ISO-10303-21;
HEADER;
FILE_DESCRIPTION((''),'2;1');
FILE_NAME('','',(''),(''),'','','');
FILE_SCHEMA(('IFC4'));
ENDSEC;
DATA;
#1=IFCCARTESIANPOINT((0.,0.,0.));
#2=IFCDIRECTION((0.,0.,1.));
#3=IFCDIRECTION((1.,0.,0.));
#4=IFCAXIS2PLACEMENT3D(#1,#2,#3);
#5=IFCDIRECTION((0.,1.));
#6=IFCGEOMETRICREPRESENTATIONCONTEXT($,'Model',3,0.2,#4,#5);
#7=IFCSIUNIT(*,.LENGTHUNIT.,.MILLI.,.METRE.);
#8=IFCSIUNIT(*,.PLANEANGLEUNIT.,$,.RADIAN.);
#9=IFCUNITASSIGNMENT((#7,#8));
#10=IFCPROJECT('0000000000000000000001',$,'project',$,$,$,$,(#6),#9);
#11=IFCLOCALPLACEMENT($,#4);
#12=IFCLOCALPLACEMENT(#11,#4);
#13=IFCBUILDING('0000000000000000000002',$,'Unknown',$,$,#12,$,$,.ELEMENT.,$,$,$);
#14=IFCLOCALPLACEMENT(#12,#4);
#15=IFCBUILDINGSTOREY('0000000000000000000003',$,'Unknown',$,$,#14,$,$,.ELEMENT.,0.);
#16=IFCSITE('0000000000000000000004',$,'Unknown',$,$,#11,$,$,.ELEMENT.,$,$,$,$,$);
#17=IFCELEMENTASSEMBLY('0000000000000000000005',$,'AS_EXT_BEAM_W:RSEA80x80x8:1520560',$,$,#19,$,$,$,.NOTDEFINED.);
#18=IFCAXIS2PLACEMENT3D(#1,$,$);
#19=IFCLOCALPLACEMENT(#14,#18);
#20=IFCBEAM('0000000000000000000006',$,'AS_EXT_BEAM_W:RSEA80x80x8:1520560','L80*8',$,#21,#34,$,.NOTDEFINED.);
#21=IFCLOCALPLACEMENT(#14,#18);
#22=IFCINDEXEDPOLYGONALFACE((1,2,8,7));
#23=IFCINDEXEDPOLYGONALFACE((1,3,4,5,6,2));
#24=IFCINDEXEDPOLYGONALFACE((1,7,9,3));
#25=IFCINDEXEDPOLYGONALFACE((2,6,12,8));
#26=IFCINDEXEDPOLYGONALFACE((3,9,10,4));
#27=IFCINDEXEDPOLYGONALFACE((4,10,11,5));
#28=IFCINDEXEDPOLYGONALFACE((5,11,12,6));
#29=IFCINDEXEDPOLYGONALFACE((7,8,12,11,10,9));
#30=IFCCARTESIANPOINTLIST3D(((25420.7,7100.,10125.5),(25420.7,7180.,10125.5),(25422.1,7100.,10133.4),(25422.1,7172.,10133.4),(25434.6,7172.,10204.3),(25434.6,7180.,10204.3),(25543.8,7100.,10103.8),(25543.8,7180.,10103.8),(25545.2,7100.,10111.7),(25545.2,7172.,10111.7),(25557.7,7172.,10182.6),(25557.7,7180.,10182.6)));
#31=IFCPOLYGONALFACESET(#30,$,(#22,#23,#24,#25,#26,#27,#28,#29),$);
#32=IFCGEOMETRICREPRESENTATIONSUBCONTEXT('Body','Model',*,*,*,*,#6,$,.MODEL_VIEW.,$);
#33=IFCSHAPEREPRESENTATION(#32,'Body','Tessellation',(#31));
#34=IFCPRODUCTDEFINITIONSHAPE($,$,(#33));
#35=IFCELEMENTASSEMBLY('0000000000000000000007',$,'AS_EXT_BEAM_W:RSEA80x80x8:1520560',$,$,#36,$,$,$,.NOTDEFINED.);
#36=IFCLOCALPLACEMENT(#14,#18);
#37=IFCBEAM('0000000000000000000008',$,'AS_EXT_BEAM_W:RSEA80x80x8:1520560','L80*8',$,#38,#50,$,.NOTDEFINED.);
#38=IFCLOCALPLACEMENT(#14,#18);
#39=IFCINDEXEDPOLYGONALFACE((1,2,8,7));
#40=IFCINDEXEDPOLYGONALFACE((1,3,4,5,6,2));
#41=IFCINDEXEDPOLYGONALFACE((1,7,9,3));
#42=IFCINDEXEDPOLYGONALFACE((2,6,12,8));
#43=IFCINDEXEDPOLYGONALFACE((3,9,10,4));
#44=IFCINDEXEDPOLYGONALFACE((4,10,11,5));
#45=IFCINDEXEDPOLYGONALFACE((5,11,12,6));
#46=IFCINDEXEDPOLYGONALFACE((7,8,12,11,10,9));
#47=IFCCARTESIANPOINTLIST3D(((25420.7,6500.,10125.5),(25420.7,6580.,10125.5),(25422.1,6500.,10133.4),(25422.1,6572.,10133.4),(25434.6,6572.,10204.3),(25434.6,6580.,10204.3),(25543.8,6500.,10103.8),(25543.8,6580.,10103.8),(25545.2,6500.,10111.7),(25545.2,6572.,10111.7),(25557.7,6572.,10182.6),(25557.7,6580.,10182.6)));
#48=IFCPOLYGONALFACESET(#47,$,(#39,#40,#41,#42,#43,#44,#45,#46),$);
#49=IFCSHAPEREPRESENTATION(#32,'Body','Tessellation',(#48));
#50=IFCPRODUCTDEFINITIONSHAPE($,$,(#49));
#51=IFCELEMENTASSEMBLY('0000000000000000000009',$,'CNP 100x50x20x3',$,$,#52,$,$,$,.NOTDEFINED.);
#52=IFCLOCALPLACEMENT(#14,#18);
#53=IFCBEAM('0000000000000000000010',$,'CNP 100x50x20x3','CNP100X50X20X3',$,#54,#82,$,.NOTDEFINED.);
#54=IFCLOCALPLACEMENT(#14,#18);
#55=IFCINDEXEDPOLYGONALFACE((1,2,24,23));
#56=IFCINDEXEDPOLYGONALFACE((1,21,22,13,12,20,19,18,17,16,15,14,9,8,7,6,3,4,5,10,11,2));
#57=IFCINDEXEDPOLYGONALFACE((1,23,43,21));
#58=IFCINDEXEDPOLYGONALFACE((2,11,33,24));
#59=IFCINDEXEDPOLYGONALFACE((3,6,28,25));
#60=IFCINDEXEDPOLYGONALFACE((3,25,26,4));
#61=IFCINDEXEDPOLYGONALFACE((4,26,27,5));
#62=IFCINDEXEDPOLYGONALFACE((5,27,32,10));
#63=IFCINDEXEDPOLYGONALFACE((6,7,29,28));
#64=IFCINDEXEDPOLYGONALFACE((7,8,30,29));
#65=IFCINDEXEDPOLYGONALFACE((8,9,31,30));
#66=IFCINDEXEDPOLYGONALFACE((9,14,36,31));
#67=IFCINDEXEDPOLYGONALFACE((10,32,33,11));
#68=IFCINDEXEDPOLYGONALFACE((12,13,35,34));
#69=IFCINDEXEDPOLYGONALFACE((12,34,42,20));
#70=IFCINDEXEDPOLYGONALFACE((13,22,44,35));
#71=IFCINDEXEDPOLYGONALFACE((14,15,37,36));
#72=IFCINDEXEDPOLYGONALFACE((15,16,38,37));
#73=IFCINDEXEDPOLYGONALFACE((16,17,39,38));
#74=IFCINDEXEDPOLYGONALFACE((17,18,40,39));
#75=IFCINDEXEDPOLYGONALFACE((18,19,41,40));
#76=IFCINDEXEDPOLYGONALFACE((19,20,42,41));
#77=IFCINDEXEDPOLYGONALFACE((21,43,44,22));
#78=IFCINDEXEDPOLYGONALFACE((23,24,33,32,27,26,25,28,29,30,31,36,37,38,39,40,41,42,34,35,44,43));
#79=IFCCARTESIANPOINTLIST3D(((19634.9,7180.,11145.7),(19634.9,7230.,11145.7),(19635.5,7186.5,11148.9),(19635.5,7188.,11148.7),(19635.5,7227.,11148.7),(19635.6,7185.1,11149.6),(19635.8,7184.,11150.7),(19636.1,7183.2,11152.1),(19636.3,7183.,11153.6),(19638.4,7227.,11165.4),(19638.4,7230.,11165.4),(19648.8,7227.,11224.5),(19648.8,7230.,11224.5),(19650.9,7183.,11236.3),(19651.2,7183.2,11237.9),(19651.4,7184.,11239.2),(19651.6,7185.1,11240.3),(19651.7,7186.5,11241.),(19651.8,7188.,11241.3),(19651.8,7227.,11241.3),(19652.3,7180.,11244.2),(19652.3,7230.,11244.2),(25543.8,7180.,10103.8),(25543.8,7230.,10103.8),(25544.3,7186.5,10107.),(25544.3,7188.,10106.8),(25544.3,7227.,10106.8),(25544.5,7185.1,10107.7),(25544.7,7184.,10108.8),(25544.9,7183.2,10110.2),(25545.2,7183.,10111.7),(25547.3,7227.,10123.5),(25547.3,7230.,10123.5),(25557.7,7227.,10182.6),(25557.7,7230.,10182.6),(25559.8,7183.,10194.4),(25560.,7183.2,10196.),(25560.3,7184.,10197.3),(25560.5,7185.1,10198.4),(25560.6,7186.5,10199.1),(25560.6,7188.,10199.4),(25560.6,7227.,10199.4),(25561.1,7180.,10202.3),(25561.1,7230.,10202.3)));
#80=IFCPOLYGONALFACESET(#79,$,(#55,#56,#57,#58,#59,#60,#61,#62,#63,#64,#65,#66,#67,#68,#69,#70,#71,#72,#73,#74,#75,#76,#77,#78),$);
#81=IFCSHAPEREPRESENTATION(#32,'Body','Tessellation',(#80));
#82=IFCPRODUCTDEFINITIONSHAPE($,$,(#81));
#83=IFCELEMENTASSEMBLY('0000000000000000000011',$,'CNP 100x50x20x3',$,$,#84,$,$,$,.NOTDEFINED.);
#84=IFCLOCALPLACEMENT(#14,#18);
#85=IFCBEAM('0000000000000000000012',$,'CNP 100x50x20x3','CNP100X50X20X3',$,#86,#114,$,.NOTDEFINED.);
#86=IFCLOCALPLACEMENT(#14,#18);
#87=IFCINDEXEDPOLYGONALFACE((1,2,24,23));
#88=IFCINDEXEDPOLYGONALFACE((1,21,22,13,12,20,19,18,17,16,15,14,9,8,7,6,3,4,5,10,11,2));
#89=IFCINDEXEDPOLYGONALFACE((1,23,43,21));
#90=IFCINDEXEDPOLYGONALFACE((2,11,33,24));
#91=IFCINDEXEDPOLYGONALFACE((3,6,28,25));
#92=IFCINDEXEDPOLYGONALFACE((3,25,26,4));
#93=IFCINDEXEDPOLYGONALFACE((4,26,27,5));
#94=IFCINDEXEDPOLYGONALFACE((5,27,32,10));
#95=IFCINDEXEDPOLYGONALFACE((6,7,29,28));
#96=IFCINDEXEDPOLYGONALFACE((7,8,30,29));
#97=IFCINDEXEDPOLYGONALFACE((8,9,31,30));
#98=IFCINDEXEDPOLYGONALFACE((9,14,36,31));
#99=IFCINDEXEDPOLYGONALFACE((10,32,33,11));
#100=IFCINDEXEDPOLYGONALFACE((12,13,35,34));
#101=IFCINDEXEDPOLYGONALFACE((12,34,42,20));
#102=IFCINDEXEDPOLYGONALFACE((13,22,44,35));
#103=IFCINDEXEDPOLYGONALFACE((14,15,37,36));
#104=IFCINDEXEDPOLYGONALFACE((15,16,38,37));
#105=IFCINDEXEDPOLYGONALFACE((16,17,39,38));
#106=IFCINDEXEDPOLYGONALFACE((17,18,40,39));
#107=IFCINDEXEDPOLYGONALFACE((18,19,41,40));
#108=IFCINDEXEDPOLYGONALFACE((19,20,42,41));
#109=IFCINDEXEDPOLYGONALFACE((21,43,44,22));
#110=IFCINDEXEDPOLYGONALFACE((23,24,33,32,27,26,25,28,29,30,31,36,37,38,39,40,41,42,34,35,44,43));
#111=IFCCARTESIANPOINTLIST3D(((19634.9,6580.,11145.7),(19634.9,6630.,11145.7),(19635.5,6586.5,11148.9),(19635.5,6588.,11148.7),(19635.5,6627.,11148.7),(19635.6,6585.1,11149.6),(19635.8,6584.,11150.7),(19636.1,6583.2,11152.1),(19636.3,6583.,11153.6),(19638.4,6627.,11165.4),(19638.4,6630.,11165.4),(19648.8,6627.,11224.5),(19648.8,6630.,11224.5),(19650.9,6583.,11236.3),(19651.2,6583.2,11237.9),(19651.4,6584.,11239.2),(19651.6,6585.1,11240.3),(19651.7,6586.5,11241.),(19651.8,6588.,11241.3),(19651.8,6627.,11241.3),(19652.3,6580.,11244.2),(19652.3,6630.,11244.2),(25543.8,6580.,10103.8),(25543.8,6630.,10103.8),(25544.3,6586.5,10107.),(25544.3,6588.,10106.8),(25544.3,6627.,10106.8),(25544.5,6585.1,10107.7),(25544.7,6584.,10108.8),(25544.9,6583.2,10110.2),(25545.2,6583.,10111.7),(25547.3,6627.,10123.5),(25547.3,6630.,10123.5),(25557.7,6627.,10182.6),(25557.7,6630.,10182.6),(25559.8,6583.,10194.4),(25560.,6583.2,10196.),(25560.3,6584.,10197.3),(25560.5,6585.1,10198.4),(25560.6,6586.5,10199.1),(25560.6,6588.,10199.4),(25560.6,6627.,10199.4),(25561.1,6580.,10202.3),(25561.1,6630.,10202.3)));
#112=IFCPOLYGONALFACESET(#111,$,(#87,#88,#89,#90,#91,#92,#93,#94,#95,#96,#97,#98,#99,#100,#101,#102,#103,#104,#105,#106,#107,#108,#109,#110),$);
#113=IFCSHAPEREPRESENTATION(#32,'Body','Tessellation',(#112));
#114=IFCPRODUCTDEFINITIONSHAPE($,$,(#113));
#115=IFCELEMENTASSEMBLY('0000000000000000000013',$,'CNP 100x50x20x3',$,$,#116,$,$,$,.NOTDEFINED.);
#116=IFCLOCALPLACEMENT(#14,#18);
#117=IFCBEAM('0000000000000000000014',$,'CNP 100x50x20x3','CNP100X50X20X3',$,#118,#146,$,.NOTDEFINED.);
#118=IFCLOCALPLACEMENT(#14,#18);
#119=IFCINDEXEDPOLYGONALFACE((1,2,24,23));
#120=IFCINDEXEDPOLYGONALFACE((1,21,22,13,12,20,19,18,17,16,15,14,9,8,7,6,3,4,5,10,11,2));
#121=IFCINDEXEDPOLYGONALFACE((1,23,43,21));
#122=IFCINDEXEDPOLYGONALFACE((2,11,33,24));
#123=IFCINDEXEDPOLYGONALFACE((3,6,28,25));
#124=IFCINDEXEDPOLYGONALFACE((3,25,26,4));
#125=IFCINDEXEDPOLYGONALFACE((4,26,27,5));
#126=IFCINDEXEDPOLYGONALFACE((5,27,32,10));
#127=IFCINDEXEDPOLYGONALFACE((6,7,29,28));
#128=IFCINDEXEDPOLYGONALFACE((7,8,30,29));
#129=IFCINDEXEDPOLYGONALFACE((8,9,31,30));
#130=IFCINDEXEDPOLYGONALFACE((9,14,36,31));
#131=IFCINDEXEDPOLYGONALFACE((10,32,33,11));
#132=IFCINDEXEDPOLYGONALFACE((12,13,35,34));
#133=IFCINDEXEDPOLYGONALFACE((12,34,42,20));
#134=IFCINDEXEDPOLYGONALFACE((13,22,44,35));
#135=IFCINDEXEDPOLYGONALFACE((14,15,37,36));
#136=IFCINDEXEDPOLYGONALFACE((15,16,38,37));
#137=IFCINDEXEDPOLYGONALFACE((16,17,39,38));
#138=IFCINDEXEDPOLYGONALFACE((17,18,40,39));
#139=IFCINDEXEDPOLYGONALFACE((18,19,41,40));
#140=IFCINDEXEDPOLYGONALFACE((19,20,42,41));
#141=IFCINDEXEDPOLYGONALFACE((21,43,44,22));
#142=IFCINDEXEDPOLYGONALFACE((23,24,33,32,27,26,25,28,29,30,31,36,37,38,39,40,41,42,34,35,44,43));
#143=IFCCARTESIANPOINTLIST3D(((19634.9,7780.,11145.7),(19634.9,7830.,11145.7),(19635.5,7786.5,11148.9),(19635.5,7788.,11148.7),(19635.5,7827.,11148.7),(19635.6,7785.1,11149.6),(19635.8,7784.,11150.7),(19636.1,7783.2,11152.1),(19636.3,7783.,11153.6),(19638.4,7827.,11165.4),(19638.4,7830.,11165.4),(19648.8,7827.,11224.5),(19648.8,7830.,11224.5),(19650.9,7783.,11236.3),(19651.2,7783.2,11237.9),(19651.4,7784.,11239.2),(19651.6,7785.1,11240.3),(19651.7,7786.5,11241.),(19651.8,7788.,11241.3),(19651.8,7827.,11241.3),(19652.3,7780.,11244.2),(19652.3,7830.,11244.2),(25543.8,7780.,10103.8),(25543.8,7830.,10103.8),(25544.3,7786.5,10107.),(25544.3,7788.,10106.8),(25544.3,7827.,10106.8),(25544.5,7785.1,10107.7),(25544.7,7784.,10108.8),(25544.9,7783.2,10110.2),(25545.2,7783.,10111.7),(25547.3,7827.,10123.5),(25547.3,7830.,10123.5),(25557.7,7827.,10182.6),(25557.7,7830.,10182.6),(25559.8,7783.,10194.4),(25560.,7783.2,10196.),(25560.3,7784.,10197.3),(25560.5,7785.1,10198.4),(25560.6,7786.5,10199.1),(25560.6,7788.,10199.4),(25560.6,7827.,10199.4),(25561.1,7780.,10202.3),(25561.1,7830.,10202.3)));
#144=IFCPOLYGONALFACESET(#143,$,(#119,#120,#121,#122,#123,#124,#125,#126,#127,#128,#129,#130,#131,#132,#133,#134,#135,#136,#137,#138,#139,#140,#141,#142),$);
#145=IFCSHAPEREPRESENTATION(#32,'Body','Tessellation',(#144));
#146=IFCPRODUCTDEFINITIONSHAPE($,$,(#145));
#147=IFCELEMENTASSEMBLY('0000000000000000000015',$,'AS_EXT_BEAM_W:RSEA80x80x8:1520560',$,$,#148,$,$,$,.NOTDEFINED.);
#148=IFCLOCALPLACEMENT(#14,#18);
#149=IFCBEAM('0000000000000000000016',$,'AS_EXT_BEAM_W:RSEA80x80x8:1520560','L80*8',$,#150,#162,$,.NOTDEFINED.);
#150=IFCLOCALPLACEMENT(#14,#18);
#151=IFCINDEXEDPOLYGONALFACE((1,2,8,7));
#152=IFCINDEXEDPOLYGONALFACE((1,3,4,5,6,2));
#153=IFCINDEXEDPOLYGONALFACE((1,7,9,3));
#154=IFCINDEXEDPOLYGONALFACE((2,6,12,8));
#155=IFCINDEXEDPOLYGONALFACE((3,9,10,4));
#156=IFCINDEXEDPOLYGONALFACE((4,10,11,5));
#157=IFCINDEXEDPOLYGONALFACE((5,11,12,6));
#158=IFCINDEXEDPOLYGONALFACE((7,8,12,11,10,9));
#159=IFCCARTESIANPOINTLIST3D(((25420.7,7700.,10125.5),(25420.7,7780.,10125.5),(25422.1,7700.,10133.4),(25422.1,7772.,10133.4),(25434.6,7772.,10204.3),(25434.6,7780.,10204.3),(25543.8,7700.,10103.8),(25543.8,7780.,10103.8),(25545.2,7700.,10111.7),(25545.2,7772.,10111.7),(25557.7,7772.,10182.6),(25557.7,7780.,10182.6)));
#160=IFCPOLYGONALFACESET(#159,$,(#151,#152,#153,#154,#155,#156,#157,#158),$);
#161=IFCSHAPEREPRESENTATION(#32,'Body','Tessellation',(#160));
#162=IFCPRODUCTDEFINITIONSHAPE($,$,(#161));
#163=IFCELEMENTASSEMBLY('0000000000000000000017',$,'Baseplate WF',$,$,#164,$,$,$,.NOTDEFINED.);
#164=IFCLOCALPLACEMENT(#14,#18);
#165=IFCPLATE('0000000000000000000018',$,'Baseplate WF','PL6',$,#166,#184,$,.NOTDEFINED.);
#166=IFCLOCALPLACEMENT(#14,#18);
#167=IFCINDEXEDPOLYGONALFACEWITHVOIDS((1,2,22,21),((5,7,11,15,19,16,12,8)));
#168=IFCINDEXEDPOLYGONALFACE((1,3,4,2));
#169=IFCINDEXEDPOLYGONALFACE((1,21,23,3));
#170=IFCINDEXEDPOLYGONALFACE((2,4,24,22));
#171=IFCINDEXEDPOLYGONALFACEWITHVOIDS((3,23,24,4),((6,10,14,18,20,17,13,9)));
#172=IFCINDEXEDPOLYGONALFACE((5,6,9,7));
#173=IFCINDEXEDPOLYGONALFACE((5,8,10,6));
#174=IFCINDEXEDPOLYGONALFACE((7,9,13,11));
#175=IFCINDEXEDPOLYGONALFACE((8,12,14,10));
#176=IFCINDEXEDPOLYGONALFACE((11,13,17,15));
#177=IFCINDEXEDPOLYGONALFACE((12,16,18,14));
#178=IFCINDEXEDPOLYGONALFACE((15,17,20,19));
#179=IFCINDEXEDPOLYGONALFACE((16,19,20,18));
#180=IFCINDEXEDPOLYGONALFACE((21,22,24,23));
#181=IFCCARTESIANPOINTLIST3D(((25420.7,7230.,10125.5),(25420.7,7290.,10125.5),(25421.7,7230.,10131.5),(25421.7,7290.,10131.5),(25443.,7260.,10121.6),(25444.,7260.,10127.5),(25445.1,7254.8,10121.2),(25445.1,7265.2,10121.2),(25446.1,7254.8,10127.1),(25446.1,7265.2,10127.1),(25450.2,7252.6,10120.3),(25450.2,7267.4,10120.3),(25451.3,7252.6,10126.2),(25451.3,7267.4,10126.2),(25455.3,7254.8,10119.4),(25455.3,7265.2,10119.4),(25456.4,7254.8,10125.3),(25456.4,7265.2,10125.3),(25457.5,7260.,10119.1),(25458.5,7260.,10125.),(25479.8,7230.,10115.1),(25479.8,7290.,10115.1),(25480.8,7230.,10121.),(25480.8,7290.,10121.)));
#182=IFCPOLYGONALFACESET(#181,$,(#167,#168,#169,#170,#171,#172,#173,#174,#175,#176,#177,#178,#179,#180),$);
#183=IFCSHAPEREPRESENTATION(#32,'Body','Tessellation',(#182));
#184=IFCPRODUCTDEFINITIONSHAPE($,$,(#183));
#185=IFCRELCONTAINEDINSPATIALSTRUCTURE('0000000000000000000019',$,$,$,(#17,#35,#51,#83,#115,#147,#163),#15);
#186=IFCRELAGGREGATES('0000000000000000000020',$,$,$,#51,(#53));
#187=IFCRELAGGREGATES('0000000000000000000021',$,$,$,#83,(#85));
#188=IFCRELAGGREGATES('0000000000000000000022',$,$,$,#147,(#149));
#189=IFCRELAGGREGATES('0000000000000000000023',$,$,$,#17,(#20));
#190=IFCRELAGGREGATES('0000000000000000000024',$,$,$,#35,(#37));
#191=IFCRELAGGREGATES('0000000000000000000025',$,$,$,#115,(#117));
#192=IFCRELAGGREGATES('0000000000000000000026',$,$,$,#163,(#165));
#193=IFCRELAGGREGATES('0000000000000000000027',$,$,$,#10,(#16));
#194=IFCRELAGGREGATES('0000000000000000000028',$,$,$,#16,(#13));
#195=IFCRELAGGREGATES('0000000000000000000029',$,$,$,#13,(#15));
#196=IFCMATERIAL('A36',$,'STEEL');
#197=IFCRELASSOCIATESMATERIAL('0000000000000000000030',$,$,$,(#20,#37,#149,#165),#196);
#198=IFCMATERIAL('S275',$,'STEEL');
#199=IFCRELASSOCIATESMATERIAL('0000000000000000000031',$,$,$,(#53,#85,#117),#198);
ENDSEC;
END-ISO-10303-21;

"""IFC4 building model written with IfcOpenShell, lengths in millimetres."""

from ifc_helpers import new_model, si_unit, direction, frame, origin_with_axes, place, context, subcontext, project, spatial, line, indexed_curve, outline, extrude, material, element, aggregate, save


model = new_model("IFC4")

# Units and contexts
model_context = context("Model", 3, precision=0.2, world=origin_with_axes(), true_north=direction((0.0, 1.0)))
body_context = subcontext(model_context, "Body", "Model", "MODEL_VIEW")
ifc_project = project(units=[si_unit("LENGTHUNIT", "METRE", prefix="MILLI"), si_unit("PLANEANGLEUNIT", "RADIAN")], contexts=[model_context])

# Site, building, storey
site_placement = place(None, origin_with_axes())
site = spatial("IfcSite", under=ifc_project, at=site_placement, Name="Unknown", CompositionType="ELEMENT")
building_placement = place(site_placement, origin_with_axes())
building = spatial("IfcBuilding", under=site, at=building_placement, Name="Unknown", CompositionType="ELEMENT")
storey_placement = place(building_placement, origin_with_axes())
storey = spatial("IfcBuildingStorey", under=building, at=storey_placement, Name="Unknown", CompositionType="ELEMENT", Elevation=0.0)

# Element assemblies, beams
assembly_1_placement = place(storey_placement, frame((25427.6, 7140.0, 10164.9), z_axis=(0.0, -1.0, 0.0), x_axis=(0.984808, 0.0, -0.173648)))
assembly_1 = element("IfcElementAssembly", 1, at=assembly_1_placement, inside=storey, Name="AS_EXT_BEAM_W:RSEA80x80x8:1520560", PredefinedType="NOTDEFINED")
ifc_material_1 = material(Name="A36", Category="STEEL")
beam_1_placement = place(assembly_1_placement, origin_with_axes())
beam_1 = element("IfcBeam", 2, at=beam_1_placement, material=ifc_material_1, Name="AS_EXT_BEAM_W:RSEA80x80x8:1520560", Description="L80*8", PredefinedType="NOTDEFINED", context=body_context, shape_type="SolidModel", body=[
    extrude(outline(indexed_curve([(-40.0, -40.0), (40.0, -40.0), (40.0, -32.0), (-32.0, -32.0), (-32.0, 40.0), (-40.0, 40.0)], segments=[line(1, 2, 3, 4, 5, 6, 1)])), frame((0.0, 0.0, 0.0), z_axis=(-1.0, 0.0, 0.0), x_axis=(0.0, 0.0, 1.0)), (0.0, 0.0, -1.0), 125.0),
])
assembly_2_placement = place(storey_placement, frame((25427.6, 6540.0, 10164.9), z_axis=(0.0, -1.0, 0.0), x_axis=(0.984808, 0.0, -0.173648)))
assembly_2 = element("IfcElementAssembly", 3, at=assembly_2_placement, inside=storey, Name="AS_EXT_BEAM_W:RSEA80x80x8:1520560", PredefinedType="NOTDEFINED")
beam_2_placement = place(assembly_2_placement, origin_with_axes())
beam_2 = element("IfcBeam", 4, at=beam_2_placement, material=ifc_material_1, Name="AS_EXT_BEAM_W:RSEA80x80x8:1520560", Description="L80*8", PredefinedType="NOTDEFINED", context=body_context, shape_type="SolidModel", body=[
    extrude(outline(indexed_curve([(-40.0, -40.0), (40.0, -40.0), (40.0, -32.0), (-32.0, -32.0), (-32.0, 40.0), (-40.0, 40.0)], segments=[line(1, 2, 3, 4, 5, 6, 1)])), frame((0.0, 0.0, 0.0), z_axis=(-1.0, 0.0, 0.0), x_axis=(0.0, 0.0, 1.0)), (0.0, 0.0, -1.0), 125.0),
])
assembly_3_placement = place(storey_placement, frame((25552.5, 7205.0, 10153.1), z_axis=(0.173648, 0.0, 0.984808), x_axis=(-0.984808, 0.0, 0.173648)))
assembly_3 = element("IfcElementAssembly", 5, at=assembly_3_placement, inside=storey, Name="CNP 100x50x20x3", PredefinedType="NOTDEFINED")
ifc_material_2 = material(Name="S275", Category="STEEL")
beam_3_placement = place(assembly_3_placement, origin_with_axes())
beam_3 = element("IfcBeam", 6, at=beam_3_placement, material=ifc_material_2, Name="CNP 100x50x20x3", Description="CNP100X50X20X3", PredefinedType="NOTDEFINED", context=body_context, shape_type="SolidModel", body=[
    extrude(outline(indexed_curve([(50.0, -25.0), (50.0, 25.0), (-50.0, 25.0), (-50.0, -25.0), (-30.0, -25.0), (-30.0, -22.0), (-47.0, -22.0), (-47.0, 17.0), (-46.8, 18.5), (-46.0, 19.9), (-44.9, 21.0), (-43.5, 21.8), (-42.0, 22.0), (42.0, 22.0), (43.5, 21.8), (44.9, 21.0), (46.0, 19.9), (46.8, 18.5), (47.0, 17.0), (47.0, -22.0), (30.0, -22.0), (30.0, -25.0)], segments=[line(1, 2, 3, 4, 5, 6, 7, 8, 9, 10, 11, 12, 13, 14, 15, 16, 17, 18, 19, 20, 21, 22, 1)])), frame((0.0, 0.0, 0.0), z_axis=(-1.0, 0.0, 0.0), x_axis=(0.0, 0.0, 1.0)), (0.0, 0.0, -1.0), 6000.0),
])
aggregate(assembly_3, [beam_3])
assembly_4_placement = place(storey_placement, frame((25552.5, 6605.0, 10153.1), z_axis=(0.173648, 0.0, 0.984808), x_axis=(-0.984808, 0.0, 0.173648)))
assembly_4 = element("IfcElementAssembly", 7, at=assembly_4_placement, inside=storey, Name="CNP 100x50x20x3", PredefinedType="NOTDEFINED")
beam_4_placement = place(assembly_4_placement, origin_with_axes())
beam_4 = element("IfcBeam", 8, at=beam_4_placement, material=ifc_material_2, Name="CNP 100x50x20x3", Description="CNP100X50X20X3", PredefinedType="NOTDEFINED", context=body_context, shape_type="SolidModel", body=[
    extrude(outline(indexed_curve([(50.0, -25.0), (50.0, 25.0), (-50.0, 25.0), (-50.0, -25.0), (-30.0, -25.0), (-30.0, -22.0), (-47.0, -22.0), (-47.0, 17.0), (-46.8, 18.5), (-46.0, 19.9), (-44.9, 21.0), (-43.5, 21.8), (-42.0, 22.0), (42.0, 22.0), (43.5, 21.8), (44.9, 21.0), (46.0, 19.9), (46.8, 18.5), (47.0, 17.0), (47.0, -22.0), (30.0, -22.0), (30.0, -25.0)], segments=[line(1, 2, 3, 4, 5, 6, 7, 8, 9, 10, 11, 12, 13, 14, 15, 16, 17, 18, 19, 20, 21, 22, 1)])), frame((0.0, 0.0, 0.0), z_axis=(-1.0, 0.0, 0.0), x_axis=(0.0, 0.0, 1.0)), (0.0, 0.0, -1.0), 6000.0),
])
aggregate(assembly_4, [beam_4])
assembly_5_placement = place(storey_placement, frame((25552.5, 7805.0, 10153.1), z_axis=(0.173648, 0.0, 0.984808), x_axis=(-0.984808, 0.0, 0.173648)))
assembly_5 = element("IfcElementAssembly", 9, at=assembly_5_placement, inside=storey, Name="CNP 100x50x20x3", PredefinedType="NOTDEFINED")
beam_5_placement = place(assembly_5_placement, origin_with_axes())
beam_5 = element("IfcBeam", 10, at=beam_5_placement, material=ifc_material_2, Name="CNP 100x50x20x3", Description="CNP100X50X20X3", PredefinedType="NOTDEFINED", context=body_context, shape_type="SolidModel", body=[
    extrude(outline(indexed_curve([(50.0, -25.0), (50.0, 25.0), (-50.0, 25.0), (-50.0, -25.0), (-30.0, -25.0), (-30.0, -22.0), (-47.0, -22.0), (-47.0, 17.0), (-46.8, 18.5), (-46.0, 19.9), (-44.9, 21.0), (-43.5, 21.8), (-42.0, 22.0), (42.0, 22.0), (43.5, 21.8), (44.9, 21.0), (46.0, 19.9), (46.8, 18.5), (47.0, 17.0), (47.0, -22.0), (30.0, -22.0), (30.0, -25.0)], segments=[line(1, 2, 3, 4, 5, 6, 7, 8, 9, 10, 11, 12, 13, 14, 15, 16, 17, 18, 19, 20, 21, 22, 1)])), frame((0.0, 0.0, 0.0), z_axis=(-1.0, 0.0, 0.0), x_axis=(0.0, 0.0, 1.0)), (0.0, 0.0, -1.0), 6000.0),
])
assembly_6_placement = place(storey_placement, frame((25427.6, 7740.0, 10164.9), z_axis=(0.0, -1.0, 0.0), x_axis=(0.984808, 0.0, -0.173648)))
assembly_6 = element("IfcElementAssembly", 11, at=assembly_6_placement, inside=storey, Name="AS_EXT_BEAM_W:RSEA80x80x8:1520560", PredefinedType="NOTDEFINED")
beam_6_placement = place(assembly_6_placement, origin_with_axes())
beam_6 = element("IfcBeam", 12, at=beam_6_placement, material=ifc_material_1, Name="AS_EXT_BEAM_W:RSEA80x80x8:1520560", Description="L80*8", PredefinedType="NOTDEFINED", context=body_context, shape_type="SolidModel", body=[
    extrude(outline(indexed_curve([(-40.0, -40.0), (40.0, -40.0), (40.0, -32.0), (-32.0, -32.0), (-32.0, 40.0), (-40.0, 40.0)], segments=[line(1, 2, 3, 4, 5, 6, 1)])), frame((0.0, 0.0, 0.0), z_axis=(-1.0, 0.0, 0.0), x_axis=(0.0, 0.0, 1.0)), (0.0, 0.0, -1.0), 125.0),
])
aggregate(assembly_6, [beam_6])

# Element assembly, plate, voiding features
assembly_7_placement = place(storey_placement, frame((25480.3, 7290.0, 10118.1), z_axis=(-0.173648, 0.0, -0.984808), x_axis=(0.0, -1.0, 0.0)))
assembly_7 = element("IfcElementAssembly", 13, at=assembly_7_placement, inside=storey, Name="Baseplate WF", PredefinedType="NOTDEFINED")
plate_1_placement = place(assembly_7_placement, origin_with_axes())
plate_1 = element("IfcPlate", 14, at=plate_1_placement, material=ifc_material_1, Name="Baseplate WF", Description="PL6", PredefinedType="NOTDEFINED", context=body_context, shape_type="SolidModel", body=[
    extrude(outline(indexed_curve([(0.0, 0.0), (60.0, 0.0), (60.0, 60.0), (0.0, 60.0)], segments=[line(1, 2, 3, 4, 1)])), frame((0.0, 0.0, 3.0), z_axis=(0.0, 0.0, 1.0), x_axis=(1.0, 0.0, 0.0)), (0.0, 0.0, -1.0), 6.0),
])
voiding_feature_1_placement = place(plate_1_placement, frame((30.0, 30.0, -3.5), z_axis=(-1.0, 0.0, 0.0), x_axis=(0.0, 0.0, 1.0)))
element("IfcVoidingFeature", 15, at=voiding_feature_1_placement, cuts=plate_1, Name="BEAM", PredefinedType="HOLE", context=body_context, shape_type="SolidModel", body=[
    extrude(outline(indexed_curve([(7.4, 0.0), (5.2, 5.2), (0.0, 7.4), (-5.2, 5.2), (-7.4, 0.0), (-5.2, -5.2), (0.0, -7.4), (5.2, -5.2)], segments=[line(1, 2, 3, 4, 5, 6, 7, 8, 1)])), frame((0.0, 0.0, 0.0), z_axis=(-1.0, 0.0, 0.0), x_axis=(0.0, 0.0, 1.0)), (0.0, 0.0, -1.0), 7.0),
])
voiding_feature_2_placement = place(plate_1_placement, frame((-80.0, 30.0, -3.5), z_axis=(-1.0, 0.0, 0.0), x_axis=(0.0, 0.0, 1.0)))
element("IfcVoidingFeature", 16, at=voiding_feature_2_placement, cuts=plate_1, Name="BEAM", PredefinedType="HOLE", context=body_context, shape_type="SolidModel", body=[
    extrude(outline(indexed_curve([(7.4, 0.0), (5.2, 5.2), (0.0, 7.4), (-5.2, 5.2), (-7.4, 0.0), (-5.2, -5.2), (0.0, -7.4), (5.2, -5.2)], segments=[line(1, 2, 3, 4, 5, 6, 7, 8, 1)])), frame((0.0, 0.0, 0.0), z_axis=(-1.0, 0.0, 0.0), x_axis=(0.0, 0.0, 1.0)), (0.0, 0.0, -1.0), 7.0),
])

aggregate(assembly_1, [beam_1])
aggregate(assembly_2, [beam_2])
aggregate(assembly_5, [beam_5])
aggregate(assembly_7, [plate_1])

save(model, "model.ifc")
